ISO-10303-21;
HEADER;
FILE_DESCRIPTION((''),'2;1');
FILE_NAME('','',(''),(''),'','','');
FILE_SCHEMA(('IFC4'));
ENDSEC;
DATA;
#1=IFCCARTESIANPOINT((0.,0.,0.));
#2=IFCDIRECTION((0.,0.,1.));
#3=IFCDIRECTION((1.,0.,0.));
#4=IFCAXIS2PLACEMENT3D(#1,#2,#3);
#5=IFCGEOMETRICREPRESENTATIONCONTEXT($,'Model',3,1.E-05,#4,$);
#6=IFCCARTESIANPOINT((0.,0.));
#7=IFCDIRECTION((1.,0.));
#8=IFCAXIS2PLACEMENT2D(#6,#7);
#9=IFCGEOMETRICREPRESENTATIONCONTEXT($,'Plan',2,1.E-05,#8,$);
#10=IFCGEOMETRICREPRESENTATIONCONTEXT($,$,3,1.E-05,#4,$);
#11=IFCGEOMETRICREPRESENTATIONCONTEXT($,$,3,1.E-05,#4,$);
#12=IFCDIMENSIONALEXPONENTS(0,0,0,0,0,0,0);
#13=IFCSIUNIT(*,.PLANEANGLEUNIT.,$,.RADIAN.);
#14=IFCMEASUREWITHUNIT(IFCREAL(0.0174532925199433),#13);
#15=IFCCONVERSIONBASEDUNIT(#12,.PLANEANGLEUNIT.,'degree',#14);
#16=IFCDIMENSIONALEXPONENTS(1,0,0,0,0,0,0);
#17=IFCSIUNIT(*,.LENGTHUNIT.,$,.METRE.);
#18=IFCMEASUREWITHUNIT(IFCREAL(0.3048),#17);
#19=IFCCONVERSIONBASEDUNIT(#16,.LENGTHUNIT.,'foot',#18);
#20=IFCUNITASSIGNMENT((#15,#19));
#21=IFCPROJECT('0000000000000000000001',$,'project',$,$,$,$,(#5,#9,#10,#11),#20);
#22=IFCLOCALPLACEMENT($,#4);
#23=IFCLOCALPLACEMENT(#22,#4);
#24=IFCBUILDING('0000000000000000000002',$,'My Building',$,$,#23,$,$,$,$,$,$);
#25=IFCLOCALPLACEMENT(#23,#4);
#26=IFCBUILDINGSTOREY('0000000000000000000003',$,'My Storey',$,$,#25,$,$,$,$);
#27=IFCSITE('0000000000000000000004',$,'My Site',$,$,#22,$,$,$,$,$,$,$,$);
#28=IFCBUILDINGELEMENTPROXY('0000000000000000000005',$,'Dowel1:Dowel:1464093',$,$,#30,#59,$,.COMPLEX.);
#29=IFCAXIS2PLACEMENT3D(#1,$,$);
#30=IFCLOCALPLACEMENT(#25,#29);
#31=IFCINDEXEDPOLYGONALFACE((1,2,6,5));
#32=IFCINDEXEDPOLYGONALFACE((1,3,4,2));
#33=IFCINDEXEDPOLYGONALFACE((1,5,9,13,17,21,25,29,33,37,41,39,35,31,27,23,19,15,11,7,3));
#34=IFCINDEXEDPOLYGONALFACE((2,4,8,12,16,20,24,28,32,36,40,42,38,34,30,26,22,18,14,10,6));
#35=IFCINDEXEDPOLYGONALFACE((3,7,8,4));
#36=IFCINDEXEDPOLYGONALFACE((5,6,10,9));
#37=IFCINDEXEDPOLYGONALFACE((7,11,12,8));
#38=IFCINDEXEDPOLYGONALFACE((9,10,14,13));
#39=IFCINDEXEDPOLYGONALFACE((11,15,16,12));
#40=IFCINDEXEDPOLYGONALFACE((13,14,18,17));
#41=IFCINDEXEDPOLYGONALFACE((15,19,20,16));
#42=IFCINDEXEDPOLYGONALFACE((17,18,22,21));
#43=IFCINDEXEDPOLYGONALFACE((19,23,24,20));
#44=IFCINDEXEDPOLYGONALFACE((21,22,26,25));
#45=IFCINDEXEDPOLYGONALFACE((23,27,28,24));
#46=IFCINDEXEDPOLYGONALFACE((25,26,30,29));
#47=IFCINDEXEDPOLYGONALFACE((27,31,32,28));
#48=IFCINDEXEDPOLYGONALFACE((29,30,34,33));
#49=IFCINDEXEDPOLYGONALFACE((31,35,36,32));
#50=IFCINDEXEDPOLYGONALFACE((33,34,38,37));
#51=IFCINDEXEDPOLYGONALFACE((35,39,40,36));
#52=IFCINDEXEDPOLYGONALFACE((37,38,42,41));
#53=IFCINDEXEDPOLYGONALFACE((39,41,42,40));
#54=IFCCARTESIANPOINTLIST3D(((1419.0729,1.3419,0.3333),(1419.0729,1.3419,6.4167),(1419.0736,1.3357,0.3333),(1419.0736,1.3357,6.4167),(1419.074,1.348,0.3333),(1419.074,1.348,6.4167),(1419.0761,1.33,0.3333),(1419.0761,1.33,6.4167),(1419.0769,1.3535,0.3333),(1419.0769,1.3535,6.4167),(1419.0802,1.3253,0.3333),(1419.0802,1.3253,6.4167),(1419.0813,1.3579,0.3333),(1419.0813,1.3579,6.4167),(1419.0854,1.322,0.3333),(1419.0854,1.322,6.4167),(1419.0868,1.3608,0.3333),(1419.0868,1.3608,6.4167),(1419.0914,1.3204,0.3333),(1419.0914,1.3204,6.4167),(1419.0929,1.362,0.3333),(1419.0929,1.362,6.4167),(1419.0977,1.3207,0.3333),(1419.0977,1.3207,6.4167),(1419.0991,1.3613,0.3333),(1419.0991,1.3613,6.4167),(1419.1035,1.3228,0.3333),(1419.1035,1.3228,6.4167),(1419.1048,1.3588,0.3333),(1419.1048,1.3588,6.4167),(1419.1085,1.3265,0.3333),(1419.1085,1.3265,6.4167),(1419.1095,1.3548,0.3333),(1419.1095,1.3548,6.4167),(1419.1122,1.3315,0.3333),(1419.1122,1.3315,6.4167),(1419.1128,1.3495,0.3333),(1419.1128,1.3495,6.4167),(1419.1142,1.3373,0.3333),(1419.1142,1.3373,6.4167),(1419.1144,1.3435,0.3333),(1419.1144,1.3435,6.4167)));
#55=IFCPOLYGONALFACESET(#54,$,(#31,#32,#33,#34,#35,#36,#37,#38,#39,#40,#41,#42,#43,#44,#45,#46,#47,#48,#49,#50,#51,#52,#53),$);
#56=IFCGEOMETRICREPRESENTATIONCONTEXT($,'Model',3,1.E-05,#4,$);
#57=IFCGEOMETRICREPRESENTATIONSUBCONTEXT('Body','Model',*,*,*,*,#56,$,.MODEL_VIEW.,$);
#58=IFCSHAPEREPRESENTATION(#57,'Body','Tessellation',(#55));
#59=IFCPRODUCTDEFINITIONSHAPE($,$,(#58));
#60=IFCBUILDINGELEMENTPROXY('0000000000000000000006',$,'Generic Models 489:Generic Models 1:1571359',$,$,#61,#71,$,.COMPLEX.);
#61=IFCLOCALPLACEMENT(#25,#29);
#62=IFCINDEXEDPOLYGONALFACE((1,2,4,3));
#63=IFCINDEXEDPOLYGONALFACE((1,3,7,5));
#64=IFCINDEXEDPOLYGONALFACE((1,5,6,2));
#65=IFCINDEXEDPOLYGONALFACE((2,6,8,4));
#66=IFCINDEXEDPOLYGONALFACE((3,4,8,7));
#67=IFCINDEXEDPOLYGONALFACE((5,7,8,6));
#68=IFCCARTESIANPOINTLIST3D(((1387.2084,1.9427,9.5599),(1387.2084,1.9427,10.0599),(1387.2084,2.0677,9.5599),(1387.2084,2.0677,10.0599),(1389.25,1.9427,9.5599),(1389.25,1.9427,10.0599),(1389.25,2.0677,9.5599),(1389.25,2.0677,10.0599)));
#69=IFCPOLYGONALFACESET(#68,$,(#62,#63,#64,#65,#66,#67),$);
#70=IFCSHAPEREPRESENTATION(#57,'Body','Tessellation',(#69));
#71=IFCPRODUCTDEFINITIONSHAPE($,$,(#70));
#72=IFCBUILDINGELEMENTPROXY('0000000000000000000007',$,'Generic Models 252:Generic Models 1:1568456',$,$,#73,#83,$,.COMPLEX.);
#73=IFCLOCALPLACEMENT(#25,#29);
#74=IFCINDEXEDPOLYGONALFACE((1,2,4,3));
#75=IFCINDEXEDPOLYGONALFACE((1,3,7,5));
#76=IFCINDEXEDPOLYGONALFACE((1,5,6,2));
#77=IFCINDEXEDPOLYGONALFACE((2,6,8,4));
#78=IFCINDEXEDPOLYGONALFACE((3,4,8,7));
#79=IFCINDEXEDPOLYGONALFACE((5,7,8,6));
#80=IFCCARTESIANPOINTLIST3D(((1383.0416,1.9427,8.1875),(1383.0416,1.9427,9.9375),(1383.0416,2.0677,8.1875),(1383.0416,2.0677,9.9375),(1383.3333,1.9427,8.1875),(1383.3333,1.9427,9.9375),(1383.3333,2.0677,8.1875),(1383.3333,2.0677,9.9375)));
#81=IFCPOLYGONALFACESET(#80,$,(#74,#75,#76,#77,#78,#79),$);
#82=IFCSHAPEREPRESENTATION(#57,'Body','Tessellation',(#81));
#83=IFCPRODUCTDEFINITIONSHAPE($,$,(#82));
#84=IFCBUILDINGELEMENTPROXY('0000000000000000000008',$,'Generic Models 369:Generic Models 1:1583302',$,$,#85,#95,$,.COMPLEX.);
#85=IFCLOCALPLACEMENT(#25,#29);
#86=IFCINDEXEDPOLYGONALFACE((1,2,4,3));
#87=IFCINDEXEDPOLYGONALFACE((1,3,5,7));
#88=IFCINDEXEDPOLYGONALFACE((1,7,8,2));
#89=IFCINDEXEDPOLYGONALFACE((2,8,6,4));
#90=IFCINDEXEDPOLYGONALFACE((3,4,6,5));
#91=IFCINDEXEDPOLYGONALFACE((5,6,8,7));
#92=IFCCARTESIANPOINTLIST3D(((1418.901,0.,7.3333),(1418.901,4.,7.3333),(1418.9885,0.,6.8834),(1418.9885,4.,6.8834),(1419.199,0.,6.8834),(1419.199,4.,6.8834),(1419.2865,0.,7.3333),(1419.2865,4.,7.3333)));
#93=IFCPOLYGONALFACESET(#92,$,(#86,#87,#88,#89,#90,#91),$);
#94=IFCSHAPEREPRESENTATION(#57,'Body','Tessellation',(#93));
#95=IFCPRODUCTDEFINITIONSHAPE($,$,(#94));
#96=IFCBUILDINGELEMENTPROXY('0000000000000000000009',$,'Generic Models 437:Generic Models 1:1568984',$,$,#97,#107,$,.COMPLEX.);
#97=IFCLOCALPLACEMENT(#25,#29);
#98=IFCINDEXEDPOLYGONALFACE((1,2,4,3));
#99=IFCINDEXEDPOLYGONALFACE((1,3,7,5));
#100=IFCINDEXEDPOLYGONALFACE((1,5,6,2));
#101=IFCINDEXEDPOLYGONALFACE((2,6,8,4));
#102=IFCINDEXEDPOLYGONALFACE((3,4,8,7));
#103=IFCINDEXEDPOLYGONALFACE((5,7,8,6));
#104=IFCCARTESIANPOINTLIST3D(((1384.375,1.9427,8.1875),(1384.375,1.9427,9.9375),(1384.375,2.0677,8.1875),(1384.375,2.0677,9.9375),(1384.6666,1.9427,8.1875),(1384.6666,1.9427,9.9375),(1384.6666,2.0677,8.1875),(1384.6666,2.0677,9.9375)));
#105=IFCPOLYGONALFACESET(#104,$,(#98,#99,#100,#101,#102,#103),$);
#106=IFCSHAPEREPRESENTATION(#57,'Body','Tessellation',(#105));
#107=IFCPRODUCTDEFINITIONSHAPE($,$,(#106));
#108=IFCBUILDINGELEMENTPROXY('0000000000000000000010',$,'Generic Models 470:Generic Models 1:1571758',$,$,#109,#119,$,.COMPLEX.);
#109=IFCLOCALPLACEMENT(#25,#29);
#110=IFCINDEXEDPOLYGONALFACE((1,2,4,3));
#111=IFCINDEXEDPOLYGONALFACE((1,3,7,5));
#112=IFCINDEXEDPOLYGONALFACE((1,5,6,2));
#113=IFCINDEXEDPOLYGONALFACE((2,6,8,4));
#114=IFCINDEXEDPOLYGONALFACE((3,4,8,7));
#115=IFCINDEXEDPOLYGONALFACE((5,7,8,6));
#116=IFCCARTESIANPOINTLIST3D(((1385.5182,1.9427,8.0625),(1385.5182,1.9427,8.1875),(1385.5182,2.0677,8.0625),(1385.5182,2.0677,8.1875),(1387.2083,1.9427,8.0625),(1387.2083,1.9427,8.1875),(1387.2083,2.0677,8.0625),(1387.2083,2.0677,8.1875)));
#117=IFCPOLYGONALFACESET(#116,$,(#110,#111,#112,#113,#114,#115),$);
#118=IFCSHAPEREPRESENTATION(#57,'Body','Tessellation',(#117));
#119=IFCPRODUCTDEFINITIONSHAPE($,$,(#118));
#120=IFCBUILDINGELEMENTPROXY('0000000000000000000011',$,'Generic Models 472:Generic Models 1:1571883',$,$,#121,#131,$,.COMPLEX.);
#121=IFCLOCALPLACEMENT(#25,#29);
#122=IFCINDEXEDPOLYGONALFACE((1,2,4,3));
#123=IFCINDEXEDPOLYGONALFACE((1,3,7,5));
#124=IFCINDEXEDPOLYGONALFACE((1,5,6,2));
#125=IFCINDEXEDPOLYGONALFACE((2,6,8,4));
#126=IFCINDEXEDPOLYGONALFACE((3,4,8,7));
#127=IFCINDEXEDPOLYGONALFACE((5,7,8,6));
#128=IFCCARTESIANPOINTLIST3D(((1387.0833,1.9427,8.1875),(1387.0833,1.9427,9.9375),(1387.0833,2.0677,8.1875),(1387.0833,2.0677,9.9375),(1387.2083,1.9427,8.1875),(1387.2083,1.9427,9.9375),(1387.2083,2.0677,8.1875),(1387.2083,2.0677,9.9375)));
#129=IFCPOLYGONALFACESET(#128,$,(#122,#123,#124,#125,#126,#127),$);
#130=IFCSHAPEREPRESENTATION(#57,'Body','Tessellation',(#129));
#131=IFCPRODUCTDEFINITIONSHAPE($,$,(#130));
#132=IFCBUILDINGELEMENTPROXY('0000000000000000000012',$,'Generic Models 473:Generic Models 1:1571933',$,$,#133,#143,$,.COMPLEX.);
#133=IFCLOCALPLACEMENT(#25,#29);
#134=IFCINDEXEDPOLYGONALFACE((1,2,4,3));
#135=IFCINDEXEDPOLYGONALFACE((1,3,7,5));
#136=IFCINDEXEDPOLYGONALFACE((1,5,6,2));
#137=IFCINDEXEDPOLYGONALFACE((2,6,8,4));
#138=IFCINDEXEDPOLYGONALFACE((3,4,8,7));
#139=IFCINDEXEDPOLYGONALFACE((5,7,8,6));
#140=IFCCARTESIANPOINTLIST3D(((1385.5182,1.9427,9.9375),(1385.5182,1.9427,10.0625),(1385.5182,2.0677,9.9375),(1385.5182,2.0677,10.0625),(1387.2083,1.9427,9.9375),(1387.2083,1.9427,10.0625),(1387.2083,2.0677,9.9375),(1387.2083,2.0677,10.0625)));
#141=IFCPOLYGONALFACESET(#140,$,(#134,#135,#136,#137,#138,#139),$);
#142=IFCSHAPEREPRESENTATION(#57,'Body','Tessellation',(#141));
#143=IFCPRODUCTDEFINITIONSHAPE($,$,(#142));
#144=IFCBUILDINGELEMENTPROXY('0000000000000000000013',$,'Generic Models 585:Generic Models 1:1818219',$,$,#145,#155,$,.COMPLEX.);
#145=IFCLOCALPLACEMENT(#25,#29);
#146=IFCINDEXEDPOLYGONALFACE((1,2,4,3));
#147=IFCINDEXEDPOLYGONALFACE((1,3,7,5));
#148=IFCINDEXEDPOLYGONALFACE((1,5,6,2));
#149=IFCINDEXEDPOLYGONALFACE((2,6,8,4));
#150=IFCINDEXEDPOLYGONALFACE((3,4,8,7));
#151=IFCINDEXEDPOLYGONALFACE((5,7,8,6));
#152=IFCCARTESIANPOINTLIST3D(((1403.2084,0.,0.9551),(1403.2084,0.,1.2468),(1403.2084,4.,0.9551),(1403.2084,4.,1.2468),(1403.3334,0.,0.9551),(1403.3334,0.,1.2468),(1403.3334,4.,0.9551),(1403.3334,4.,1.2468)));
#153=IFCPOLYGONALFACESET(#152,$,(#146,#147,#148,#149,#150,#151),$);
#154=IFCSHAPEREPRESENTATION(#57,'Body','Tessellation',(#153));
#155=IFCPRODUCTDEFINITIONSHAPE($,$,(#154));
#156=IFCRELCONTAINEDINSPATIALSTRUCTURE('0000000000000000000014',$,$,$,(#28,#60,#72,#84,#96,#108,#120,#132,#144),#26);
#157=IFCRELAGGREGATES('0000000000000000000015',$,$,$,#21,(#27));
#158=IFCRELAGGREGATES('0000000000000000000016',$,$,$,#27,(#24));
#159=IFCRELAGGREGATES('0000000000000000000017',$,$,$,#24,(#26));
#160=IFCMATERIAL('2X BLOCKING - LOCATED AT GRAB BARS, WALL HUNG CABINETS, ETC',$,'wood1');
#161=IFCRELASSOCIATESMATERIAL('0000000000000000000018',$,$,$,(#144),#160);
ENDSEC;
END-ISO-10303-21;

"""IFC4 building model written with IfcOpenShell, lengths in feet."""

from ifc_helpers import new_model, entity, si_unit, converted_unit, frame, origin_with_axes, origin_2d_with_axis, place, context, subcontext, project, spatial, polyline, line, indexed_curve, circle, outline, extrude, material, element, save


model = new_model("IFC4")

# Units and contexts
model_context_1 = context("Model", 3, precision=1e-05, world=origin_with_axes())
plan_context = context("Plan", 2, precision=1e-05, world=origin_2d_with_axis())
model_context_2 = context("Model", 3, precision=1e-05, world=origin_with_axes())
context_of_model_1 = context(None, 3, precision=1e-05, world=origin_with_axes())
context_of_model_2 = context(None, 3, precision=1e-05, world=origin_with_axes())
body_context_1 = subcontext(model_context_2, "Body", "Model", "MODEL_VIEW")
ifc_project = project(units=[converted_unit("PLANEANGLEUNIT", "degree", entity("IfcReal", 0.0174532925199433), si_unit("PLANEANGLEUNIT", "RADIAN"), dimensions=[0, 0, 0, 0, 0, 0, 0]), converted_unit("LENGTHUNIT", "foot", entity("IfcReal", 0.3048), si_unit("LENGTHUNIT", "METRE"), dimensions=[1, 0, 0, 0, 0, 0, 0])], contexts=[model_context_1, plan_context, context_of_model_1, context_of_model_2])

# Site, building, storey
site_placement = place(None, origin_with_axes())
site = spatial("IfcSite", under=ifc_project, at=site_placement, Name="My Site")
building_placement = place(site_placement, origin_with_axes())
building = spatial("IfcBuilding", under=site, at=building_placement, Name="My Building")
storey_placement = place(building_placement, origin_with_axes())
storey = spatial("IfcBuildingStorey", under=building, at=storey_placement, Name="My Storey")

# Building element proxies
proxy_1_placement = place(storey_placement, frame((1419.0729, 1.3203, 0.3333), z_axis=(0.0, 0.0, 1.0), x_axis=(0.0, 1.0, 0.0)))
element("IfcBuildingElementProxy", 1, at=proxy_1_placement, inside=storey, Name="Dowel1:Dowel:1464093", PredefinedType="COMPLEX", context=body_context_1, shape_type="SweptSolid", body=[
    extrude(circle(Radius=0.0208, at=origin_2d_with_axis()), frame((0.0208, -0.0208, 0.0), z_axis=(0.0, 0.0, -1.0), x_axis=(-0.464723, -0.885456, 0.0)), (0.0, 0.0, -1.0), 6.0833),
])
proxy_2_placement = place(storey_placement, frame((1387.2084, 1.9427, 9.5599), z_axis=(1.0, 0.0, 0.0), x_axis=(0.0, 0.0, -1.0)))
element("IfcBuildingElementProxy", 2, at=proxy_2_placement, inside=storey, Name="Generic Models 489:Generic Models 1:1571359", PredefinedType="COMPLEX", context=body_context_1, shape_type="SweptSolid", body=[
    extrude(outline(polyline([(-0.0625, -0.25), (0.0625, -0.25), (0.0625, 0.25), (-0.0625, 0.25), (-0.0625, -0.25)])), frame((-0.25, 0.0625, 0.0), z_axis=(0.0, 0.0, -1.0), x_axis=(0.0, -1.0, 0.0)), (0.0, 0.0, -1.0), 2.0417),
])
proxy_3_placement = place(storey_placement, frame((1383.0416, 1.9427, 8.1875), z_axis=(0.0, 0.0, 1.0), x_axis=(1.0, 0.0, 0.0)))
element("IfcBuildingElementProxy", 3, at=proxy_3_placement, inside=storey, Name="Generic Models 252:Generic Models 1:1568456", PredefinedType="COMPLEX", context=body_context_1, shape_type="SweptSolid", body=[
    extrude(outline(polyline([(-0.1458, -0.0625), (0.1458, -0.0625), (0.1458, 0.0625), (-0.1458, 0.0625), (-0.1458, -0.0625)])), frame((0.1458, 0.0625, 0.0), z_axis=(0.0, 0.0, -1.0), x_axis=(-1.0, 0.0, 0.0)), (0.0, 0.0, -1.0), 1.75),
])
proxy_4_placement = place(storey_placement, frame((1419.2865, 0.0, 6.8834), z_axis=(0.0, 1.0, 0.0), x_axis=(0.0, 0.0, 1.0)))
element("IfcBuildingElementProxy", 4, at=proxy_4_placement, inside=storey, Name="Generic Models 369:Generic Models 1:1583302", PredefinedType="COMPLEX", context=body_context_1, shape_type="SweptSolid", body=[
    extrude(outline(indexed_curve([(-0.1053, 0.225), (0.1053, 0.225), (0.1927, -0.225), (-0.1927, -0.225)], segments=[line(4, 1), line(1, 2), line(2, 3), line(3, 4)], self_intersect=False)), frame((0.225, -0.1927, 4.0), z_axis=(0.0, 0.0, -1.0), x_axis=(0.0, -1.0, 0.0)), (0.0, 0.0, 1.0), 4.0),
])
proxy_5_placement = place(storey_placement, frame((1384.375, 1.9427, 8.1875), z_axis=(0.0, 0.0, 1.0), x_axis=(1.0, 0.0, 0.0)))
element("IfcBuildingElementProxy", 5, at=proxy_5_placement, inside=storey, Name="Generic Models 437:Generic Models 1:1568984", PredefinedType="COMPLEX", context=body_context_1, shape_type="SweptSolid", body=[
    extrude(outline(polyline([(-0.1458, -0.0625), (0.1458, -0.0625), (0.1458, 0.0625), (-0.1458, 0.0625), (-0.1458, -0.0625)])), frame((0.1458, 0.0625, 0.0), z_axis=(0.0, 0.0, -1.0), x_axis=(-1.0, 0.0, 0.0)), (0.0, 0.0, -1.0), 1.75),
])
proxy_6_placement = place(storey_placement, frame((1385.5182, 1.9427, 8.0625), z_axis=(1.0, 0.0, 0.0), x_axis=(0.0, 0.0, -1.0)))
element("IfcBuildingElementProxy", 6, at=proxy_6_placement, inside=storey, Name="Generic Models 470:Generic Models 1:1571758", PredefinedType="COMPLEX", context=body_context_1, shape_type="SweptSolid", body=[
    extrude(outline(polyline([(-0.0625, -0.0625), (0.0625, -0.0625), (0.0625, 0.0625), (-0.0625, 0.0625), (-0.0625, -0.0625)])), frame((-0.0625, 0.0625, 0.0), z_axis=(0.0, 0.0, -1.0), x_axis=(1.0, 0.0, 0.0)), (0.0, 0.0, -1.0), 1.6902),
])
proxy_7_placement = place(storey_placement, frame((1387.0833, 1.9427, 8.1875), z_axis=(0.0, 0.0, 1.0), x_axis=(0.0, 1.0, 0.0)))
element("IfcBuildingElementProxy", 7, at=proxy_7_placement, inside=storey, Name="Generic Models 472:Generic Models 1:1571883", PredefinedType="COMPLEX", context=body_context_1, shape_type="SweptSolid", body=[
    extrude(outline(polyline([(-0.0625, -0.0625), (0.0625, -0.0625), (0.0625, 0.0625), (-0.0625, 0.0625), (-0.0625, -0.0625)])), frame((0.0625, -0.0625, 0.0), z_axis=(0.0, 0.0, -1.0), x_axis=(-1.0, 0.0, 0.0)), (0.0, 0.0, -1.0), 1.75),
])
proxy_8_placement = place(storey_placement, frame((1385.5182, 1.9427, 9.9375), z_axis=(1.0, 0.0, 0.0), x_axis=(0.0, 0.0, -1.0)))
element("IfcBuildingElementProxy", 8, at=proxy_8_placement, inside=storey, Name="Generic Models 473:Generic Models 1:1571933", PredefinedType="COMPLEX", context=body_context_1, shape_type="SweptSolid", body=[
    extrude(outline(polyline([(-0.0625, -0.0625), (0.0625, -0.0625), (0.0625, 0.0625), (-0.0625, 0.0625), (-0.0625, -0.0625)])), frame((-0.0625, 0.0625, 0.0), z_axis=(0.0, 0.0, -1.0), x_axis=(1.0, 0.0, 0.0)), (0.0, 0.0, -1.0), 1.6902),
])
ifc_material_1 = material(Name="2X BLOCKING - LOCATED AT GRAB BARS, WALL HUNG CABINETS, ETC", Category="wood1")
proxy_9_placement = place(storey_placement, frame((1403.2084, 0.0, 0.9551), z_axis=(0.0, 0.0, 1.0), x_axis=(0.0, 1.0, 0.0)))
element("IfcBuildingElementProxy", 9, at=proxy_9_placement, inside=storey, material=ifc_material_1, Name="Generic Models 585:Generic Models 1:1818219", PredefinedType="COMPLEX", context=body_context_1, shape_type="SweptSolid", body=[
    extrude(outline(polyline([(-2.0, -0.0625), (2.0, -0.0625), (2.0, 0.0625), (-2.0, 0.0625), (-2.0, -0.0625)])), frame((2.0, -0.0625, 0.0), z_axis=(0.0, 0.0, -1.0), x_axis=(1.0, 0.0, 0.0)), (0.0, 0.0, -1.0), 0.2917),
])

save(model, "model.ifc")
